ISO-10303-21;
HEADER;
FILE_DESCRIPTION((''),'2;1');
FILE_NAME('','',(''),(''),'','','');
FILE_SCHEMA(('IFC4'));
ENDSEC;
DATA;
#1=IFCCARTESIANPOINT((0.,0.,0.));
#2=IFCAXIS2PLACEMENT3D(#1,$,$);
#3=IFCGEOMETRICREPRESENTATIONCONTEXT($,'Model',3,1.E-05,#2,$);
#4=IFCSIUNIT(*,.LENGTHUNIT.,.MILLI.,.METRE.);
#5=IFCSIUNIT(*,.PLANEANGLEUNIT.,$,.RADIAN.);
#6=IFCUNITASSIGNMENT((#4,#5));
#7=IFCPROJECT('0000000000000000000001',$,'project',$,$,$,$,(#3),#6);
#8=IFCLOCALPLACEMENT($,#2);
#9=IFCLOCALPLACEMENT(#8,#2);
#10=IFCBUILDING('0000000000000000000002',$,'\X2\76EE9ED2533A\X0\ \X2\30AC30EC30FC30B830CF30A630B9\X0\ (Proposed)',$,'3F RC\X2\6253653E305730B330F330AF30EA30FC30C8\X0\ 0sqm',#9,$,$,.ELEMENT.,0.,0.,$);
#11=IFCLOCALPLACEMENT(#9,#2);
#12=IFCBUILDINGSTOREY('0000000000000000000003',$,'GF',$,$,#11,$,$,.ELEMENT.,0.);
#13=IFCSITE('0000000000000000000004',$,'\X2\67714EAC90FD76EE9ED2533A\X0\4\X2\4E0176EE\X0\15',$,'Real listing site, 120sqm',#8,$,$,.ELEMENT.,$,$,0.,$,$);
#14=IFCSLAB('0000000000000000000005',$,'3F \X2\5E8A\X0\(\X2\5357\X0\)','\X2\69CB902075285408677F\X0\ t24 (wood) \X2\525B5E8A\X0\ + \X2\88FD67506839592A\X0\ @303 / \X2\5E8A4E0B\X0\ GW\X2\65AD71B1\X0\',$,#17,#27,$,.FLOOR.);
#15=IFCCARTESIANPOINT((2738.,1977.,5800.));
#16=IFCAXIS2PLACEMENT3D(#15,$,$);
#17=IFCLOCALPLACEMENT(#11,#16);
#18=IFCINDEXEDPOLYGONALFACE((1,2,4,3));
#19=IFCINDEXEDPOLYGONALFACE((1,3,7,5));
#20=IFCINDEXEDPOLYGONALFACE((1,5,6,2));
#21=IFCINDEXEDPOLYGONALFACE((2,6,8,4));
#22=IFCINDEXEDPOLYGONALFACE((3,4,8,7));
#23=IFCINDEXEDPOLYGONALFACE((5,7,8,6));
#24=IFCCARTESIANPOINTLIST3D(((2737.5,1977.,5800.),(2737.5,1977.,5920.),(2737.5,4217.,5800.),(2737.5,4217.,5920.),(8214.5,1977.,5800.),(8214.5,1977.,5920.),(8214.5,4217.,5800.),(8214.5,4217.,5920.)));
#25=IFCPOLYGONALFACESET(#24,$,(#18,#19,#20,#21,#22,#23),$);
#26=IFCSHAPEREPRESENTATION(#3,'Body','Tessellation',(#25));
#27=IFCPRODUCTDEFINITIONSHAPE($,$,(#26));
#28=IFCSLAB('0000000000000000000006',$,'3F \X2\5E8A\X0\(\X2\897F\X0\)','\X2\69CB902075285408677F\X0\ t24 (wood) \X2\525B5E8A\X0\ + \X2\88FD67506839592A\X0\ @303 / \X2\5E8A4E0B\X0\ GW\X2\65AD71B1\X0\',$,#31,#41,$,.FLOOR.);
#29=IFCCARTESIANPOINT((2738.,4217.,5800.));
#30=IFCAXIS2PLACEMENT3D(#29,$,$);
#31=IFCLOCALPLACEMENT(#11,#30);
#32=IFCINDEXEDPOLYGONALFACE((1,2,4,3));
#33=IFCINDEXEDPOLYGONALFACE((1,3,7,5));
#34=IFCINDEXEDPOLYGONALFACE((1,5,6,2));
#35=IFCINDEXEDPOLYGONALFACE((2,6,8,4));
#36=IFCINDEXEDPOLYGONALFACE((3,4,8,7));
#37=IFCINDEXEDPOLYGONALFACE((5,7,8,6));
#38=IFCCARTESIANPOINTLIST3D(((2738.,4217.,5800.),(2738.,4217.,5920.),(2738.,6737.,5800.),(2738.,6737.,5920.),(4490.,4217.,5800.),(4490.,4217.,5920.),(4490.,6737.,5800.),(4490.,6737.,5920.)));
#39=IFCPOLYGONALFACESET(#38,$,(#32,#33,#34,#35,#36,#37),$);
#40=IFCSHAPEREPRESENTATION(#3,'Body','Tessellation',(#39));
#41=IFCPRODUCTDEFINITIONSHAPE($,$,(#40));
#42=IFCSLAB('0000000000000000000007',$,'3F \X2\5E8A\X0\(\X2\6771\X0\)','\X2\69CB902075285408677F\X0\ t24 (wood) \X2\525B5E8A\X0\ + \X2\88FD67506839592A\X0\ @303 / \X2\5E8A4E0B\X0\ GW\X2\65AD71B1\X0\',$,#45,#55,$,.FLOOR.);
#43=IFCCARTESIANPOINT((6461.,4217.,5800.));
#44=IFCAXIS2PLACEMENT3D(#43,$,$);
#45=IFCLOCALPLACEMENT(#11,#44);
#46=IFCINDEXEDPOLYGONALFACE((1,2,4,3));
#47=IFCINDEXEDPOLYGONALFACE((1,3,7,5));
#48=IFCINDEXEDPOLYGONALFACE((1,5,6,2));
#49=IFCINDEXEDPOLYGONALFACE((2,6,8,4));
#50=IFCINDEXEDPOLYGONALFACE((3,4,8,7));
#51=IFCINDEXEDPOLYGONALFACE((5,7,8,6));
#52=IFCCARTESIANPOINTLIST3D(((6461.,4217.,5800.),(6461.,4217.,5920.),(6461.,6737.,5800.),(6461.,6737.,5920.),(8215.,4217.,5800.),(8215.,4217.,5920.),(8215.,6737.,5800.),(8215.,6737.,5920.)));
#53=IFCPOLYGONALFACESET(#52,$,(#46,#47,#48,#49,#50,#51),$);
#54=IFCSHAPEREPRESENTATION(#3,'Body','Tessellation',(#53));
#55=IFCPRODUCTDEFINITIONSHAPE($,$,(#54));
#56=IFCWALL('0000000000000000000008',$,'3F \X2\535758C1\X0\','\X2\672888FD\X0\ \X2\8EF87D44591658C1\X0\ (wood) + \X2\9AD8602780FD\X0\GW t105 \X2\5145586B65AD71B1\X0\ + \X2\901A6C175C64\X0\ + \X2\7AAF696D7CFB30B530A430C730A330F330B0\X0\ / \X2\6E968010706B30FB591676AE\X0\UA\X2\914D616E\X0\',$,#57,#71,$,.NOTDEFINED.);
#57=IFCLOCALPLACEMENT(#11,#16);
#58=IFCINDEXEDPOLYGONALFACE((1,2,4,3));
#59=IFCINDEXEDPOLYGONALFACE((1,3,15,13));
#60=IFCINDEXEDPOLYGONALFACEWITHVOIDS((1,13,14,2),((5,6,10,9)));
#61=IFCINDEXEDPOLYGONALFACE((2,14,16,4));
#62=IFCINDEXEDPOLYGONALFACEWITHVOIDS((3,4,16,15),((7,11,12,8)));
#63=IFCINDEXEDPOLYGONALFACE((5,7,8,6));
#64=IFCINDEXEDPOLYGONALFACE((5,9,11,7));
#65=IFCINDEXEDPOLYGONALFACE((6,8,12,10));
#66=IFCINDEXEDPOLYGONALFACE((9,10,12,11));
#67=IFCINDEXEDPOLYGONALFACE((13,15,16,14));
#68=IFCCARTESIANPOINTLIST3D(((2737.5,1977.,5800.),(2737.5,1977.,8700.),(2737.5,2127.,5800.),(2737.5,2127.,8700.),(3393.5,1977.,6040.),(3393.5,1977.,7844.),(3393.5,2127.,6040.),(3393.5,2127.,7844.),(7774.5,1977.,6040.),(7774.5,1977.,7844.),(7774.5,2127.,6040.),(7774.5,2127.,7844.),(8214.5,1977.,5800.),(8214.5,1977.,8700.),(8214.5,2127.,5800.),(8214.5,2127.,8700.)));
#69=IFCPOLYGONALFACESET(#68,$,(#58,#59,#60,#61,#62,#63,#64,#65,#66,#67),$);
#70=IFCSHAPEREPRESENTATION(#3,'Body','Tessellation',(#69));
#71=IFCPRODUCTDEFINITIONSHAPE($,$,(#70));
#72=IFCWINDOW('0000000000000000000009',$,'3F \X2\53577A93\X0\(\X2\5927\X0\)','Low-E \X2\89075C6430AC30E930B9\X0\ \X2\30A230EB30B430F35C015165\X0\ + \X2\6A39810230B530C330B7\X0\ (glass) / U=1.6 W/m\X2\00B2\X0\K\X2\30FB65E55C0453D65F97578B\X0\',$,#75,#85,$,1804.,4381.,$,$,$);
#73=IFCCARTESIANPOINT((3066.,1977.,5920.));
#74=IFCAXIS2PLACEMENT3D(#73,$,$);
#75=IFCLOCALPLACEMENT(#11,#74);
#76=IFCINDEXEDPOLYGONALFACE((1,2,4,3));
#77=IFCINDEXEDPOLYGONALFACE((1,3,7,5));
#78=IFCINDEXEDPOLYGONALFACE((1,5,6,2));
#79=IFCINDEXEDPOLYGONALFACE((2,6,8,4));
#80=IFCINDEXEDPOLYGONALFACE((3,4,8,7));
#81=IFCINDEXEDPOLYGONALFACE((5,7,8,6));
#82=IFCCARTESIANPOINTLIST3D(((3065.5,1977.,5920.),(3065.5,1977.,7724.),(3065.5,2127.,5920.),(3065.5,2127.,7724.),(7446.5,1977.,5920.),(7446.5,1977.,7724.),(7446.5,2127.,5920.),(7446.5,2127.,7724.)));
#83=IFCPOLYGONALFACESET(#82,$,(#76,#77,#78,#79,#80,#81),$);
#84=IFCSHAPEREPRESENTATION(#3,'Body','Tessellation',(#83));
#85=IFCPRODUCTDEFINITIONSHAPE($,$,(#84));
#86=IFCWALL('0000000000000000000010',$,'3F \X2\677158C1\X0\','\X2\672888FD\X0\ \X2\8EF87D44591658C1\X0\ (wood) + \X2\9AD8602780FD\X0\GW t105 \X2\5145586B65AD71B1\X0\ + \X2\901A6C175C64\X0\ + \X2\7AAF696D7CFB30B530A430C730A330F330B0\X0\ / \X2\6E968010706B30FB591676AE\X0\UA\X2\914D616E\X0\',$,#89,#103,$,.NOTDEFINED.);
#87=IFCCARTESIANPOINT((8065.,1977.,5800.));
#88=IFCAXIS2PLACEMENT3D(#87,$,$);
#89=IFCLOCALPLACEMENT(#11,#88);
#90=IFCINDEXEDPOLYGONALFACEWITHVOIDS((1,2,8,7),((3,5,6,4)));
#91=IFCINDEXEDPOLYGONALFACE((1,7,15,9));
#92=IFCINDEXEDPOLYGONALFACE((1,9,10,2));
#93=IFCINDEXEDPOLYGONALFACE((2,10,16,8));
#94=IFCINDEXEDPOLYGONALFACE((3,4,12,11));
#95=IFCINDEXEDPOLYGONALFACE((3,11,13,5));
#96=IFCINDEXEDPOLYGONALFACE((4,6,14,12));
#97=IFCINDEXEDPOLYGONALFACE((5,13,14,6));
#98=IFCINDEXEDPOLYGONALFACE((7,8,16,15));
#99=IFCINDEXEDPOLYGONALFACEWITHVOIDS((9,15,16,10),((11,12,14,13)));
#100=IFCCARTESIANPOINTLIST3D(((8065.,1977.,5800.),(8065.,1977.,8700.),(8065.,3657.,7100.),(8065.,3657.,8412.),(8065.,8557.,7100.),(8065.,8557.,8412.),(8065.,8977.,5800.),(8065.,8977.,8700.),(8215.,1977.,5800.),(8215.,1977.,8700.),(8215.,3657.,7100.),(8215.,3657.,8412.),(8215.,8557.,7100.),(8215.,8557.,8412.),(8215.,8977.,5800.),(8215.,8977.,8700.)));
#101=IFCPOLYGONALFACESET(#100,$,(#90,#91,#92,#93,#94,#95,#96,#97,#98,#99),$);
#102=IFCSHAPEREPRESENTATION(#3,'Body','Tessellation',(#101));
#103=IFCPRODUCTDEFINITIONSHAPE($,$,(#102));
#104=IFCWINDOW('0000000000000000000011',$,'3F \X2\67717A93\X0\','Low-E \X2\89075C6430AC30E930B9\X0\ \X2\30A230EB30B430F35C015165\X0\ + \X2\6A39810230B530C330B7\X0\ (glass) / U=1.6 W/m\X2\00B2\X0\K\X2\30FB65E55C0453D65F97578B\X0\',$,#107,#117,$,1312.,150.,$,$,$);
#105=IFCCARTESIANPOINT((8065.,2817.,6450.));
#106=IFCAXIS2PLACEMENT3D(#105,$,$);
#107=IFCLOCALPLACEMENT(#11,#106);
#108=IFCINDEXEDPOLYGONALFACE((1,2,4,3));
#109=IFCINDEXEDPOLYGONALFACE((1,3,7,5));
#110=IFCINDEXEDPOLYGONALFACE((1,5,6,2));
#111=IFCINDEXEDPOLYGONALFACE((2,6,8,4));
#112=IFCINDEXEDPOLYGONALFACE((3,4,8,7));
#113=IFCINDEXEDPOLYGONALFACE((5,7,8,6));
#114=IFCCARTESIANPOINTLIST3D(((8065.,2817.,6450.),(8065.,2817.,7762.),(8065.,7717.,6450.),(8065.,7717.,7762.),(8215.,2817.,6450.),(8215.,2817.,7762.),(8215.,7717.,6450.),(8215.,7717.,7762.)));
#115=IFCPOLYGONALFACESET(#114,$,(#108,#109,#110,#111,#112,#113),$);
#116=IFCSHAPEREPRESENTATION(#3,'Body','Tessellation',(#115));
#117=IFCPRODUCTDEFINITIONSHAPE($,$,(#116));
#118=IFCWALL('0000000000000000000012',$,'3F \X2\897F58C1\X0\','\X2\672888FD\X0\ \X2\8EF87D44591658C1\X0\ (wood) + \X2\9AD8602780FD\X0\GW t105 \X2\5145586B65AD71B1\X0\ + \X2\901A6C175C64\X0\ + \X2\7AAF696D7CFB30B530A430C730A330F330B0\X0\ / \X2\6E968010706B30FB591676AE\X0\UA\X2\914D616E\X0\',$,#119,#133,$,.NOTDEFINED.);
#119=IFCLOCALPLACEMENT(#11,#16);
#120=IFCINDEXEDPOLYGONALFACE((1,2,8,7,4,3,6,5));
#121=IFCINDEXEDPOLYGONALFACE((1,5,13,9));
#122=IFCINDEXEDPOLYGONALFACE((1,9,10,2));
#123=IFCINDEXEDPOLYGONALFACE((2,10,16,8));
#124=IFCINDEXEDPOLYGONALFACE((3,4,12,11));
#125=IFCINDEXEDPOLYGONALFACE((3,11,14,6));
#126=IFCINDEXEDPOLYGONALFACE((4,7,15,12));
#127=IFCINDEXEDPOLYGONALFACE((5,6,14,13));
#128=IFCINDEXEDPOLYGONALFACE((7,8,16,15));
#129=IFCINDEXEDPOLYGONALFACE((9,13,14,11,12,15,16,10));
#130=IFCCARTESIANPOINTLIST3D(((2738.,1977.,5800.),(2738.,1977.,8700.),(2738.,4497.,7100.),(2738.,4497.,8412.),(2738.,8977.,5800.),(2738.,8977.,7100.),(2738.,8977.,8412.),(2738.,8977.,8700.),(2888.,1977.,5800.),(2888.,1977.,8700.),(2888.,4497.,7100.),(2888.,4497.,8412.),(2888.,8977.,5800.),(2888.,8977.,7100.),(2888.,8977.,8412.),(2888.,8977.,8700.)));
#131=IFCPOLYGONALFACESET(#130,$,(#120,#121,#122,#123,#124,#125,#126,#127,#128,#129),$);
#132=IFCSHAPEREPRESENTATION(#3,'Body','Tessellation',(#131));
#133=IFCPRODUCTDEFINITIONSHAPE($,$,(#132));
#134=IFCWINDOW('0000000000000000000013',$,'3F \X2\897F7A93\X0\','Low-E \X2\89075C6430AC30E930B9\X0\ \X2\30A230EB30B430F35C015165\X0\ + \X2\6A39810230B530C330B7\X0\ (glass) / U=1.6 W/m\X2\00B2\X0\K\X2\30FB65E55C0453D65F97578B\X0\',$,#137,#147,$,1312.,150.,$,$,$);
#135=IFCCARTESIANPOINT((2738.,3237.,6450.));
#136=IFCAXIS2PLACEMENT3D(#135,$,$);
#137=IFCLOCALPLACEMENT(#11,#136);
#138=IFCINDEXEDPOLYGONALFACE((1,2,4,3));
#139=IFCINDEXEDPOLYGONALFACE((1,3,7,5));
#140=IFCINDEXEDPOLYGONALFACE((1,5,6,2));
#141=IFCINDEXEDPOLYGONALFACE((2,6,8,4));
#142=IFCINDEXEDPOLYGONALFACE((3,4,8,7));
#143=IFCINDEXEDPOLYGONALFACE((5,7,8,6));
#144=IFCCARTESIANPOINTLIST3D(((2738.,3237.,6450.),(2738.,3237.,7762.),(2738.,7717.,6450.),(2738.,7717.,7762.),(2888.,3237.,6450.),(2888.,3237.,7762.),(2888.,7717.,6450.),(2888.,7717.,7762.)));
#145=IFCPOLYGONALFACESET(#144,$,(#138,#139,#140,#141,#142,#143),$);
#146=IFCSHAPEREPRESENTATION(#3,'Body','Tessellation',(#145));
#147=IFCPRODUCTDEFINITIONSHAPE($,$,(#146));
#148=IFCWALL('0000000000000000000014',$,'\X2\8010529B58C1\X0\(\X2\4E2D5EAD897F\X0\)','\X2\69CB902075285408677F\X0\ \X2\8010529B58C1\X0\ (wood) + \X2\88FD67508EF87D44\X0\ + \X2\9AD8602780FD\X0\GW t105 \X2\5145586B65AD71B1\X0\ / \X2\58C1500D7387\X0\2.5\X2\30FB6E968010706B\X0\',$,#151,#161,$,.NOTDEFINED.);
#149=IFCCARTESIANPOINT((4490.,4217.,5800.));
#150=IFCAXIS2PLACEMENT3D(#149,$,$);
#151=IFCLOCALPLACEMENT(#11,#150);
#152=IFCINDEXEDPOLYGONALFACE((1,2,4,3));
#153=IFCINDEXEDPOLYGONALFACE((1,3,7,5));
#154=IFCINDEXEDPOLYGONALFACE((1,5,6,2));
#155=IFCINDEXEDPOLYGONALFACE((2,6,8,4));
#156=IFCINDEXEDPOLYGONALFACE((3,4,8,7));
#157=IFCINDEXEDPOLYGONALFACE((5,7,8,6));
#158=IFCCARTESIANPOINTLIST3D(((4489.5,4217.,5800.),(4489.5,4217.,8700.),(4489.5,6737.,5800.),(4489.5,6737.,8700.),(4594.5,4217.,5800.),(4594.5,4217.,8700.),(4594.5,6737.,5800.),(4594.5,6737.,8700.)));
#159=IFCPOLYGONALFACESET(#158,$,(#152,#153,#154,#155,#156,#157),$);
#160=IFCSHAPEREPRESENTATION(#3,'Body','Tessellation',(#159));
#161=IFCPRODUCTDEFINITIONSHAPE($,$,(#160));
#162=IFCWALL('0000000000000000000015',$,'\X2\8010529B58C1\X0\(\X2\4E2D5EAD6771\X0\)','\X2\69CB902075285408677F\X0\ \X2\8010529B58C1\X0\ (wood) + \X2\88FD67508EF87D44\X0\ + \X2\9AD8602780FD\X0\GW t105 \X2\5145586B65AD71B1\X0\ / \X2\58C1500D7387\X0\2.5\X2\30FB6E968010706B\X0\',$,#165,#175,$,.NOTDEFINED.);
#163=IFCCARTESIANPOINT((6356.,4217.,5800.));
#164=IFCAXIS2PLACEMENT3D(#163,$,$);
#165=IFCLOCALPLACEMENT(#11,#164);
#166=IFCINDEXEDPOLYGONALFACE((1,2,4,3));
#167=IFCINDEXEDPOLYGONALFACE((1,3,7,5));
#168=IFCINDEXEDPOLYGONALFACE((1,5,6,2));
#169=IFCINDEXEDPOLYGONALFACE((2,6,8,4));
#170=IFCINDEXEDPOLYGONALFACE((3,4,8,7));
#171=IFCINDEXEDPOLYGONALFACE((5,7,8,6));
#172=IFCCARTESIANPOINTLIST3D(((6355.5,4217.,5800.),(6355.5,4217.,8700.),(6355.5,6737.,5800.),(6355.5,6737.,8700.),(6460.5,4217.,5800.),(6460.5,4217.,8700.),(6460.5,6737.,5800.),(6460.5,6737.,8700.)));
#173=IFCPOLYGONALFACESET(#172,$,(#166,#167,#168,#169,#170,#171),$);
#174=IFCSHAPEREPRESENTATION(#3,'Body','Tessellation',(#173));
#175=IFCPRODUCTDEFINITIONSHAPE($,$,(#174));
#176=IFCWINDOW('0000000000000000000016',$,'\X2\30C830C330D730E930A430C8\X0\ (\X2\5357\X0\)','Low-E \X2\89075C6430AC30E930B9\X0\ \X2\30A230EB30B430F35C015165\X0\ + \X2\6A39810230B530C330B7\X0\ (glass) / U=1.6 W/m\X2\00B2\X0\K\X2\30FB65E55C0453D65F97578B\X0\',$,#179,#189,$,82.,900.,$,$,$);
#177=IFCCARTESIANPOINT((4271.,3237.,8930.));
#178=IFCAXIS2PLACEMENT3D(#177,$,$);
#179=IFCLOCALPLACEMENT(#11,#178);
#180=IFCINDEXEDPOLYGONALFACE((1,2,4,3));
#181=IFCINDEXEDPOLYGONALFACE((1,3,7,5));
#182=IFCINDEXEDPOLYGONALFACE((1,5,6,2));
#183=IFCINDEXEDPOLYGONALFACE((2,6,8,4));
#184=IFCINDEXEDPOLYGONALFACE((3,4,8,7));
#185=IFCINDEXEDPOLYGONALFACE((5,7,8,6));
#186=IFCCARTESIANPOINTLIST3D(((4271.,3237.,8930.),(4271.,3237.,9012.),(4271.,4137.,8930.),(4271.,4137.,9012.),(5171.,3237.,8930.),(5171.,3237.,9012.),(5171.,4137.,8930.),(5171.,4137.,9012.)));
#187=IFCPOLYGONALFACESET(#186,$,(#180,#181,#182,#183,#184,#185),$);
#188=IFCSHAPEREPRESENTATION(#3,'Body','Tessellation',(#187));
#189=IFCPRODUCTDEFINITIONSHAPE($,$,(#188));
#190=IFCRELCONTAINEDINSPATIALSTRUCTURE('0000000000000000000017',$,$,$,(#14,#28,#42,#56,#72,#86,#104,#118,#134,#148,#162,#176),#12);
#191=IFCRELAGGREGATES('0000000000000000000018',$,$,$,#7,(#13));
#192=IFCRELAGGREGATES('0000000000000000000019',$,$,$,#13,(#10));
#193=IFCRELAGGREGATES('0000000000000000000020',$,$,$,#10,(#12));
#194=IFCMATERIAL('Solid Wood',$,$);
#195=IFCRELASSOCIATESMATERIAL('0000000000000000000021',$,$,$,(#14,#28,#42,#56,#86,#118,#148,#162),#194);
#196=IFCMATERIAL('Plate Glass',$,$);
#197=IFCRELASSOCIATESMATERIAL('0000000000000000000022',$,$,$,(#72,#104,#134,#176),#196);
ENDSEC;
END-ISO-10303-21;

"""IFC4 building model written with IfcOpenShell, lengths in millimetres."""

from ifc_helpers import new_model, si_unit, frame, frame_2d, origin, place, context, project, spatial, rectangle, extrude, material, element, fill, save


model = new_model("IFC4")

# Units and contexts
model_context = context("Model", 3, precision=1e-05, world=origin())
ifc_project = project(units=[si_unit("LENGTHUNIT", "METRE", prefix="MILLI"), si_unit("PLANEANGLEUNIT", "RADIAN")], contexts=[model_context])

# Site, building, storey
site_placement = place(None, origin())
site = spatial("IfcSite", under=ifc_project, at=site_placement, Name="東京都目黒区4丁目15", ObjectType="Real listing site, 120sqm", CompositionType="ELEMENT", RefElevation=0.0)
building_placement = place(site_placement, origin())
building = spatial("IfcBuilding", under=site, at=building_placement, Name="目黒区 ガレージハウス (Proposed)", ObjectType="3F RC打放しコンクリート 0sqm", CompositionType="ELEMENT", ElevationOfRefHeight=0.0, ElevationOfTerrain=0.0)
storey_placement = place(building_placement, origin())
storey = spatial("IfcBuildingStorey", under=building, at=storey_placement, Name="GF", CompositionType="ELEMENT", Elevation=0.0)

# Slabs
ifc_material_1 = material(Name="Solid Wood")
slab_1_placement = place(storey_placement, frame((2738.0, 1977.0, 5800.0)))
element("IfcSlab", 1, at=slab_1_placement, inside=storey, material=ifc_material_1, Name="3F 床(南)", Description="構造用合板 t24 (wood) 剛床 + 製材根太 @303 / 床下 GW断熱", PredefinedType="FLOOR", context=model_context, shape_type="SweptSolid", body=[
    extrude(rectangle(XDim=5477.0, YDim=2240.0, at=frame_2d((2738.0, 1120.0))), frame((2738.0, 1977.0, 5800.0)), (0.0, 0.0, 1.0), 120.0),
])
slab_2_placement = place(storey_placement, frame((2738.0, 4217.0, 5800.0)))
element("IfcSlab", 2, at=slab_2_placement, inside=storey, material=ifc_material_1, Name="3F 床(西)", Description="構造用合板 t24 (wood) 剛床 + 製材根太 @303 / 床下 GW断熱", PredefinedType="FLOOR", context=model_context, shape_type="SweptSolid", body=[
    extrude(rectangle(XDim=1752.0, YDim=2520.0, at=frame_2d((876.0, 1260.0))), frame((2738.0, 4217.0, 5800.0)), (0.0, 0.0, 1.0), 120.0),
])
slab_3_placement = place(storey_placement, frame((6461.0, 4217.0, 5800.0)))
element("IfcSlab", 3, at=slab_3_placement, inside=storey, material=ifc_material_1, Name="3F 床(東)", Description="構造用合板 t24 (wood) 剛床 + 製材根太 @303 / 床下 GW断熱", PredefinedType="FLOOR", context=model_context, shape_type="SweptSolid", body=[
    extrude(rectangle(XDim=1754.0, YDim=2520.0, at=frame_2d((877.0, 1260.0))), frame((6461.0, 4217.0, 5800.0)), (0.0, 0.0, 1.0), 120.0),
])

# Walls, openings, windows
wall_1_placement = place(storey_placement, frame((2738.0, 1977.0, 5800.0)))
wall_1 = element("IfcWall", 4, at=wall_1_placement, inside=storey, material=ifc_material_1, Name="3F 南壁", Description="木製 軸組外壁 (wood) + 高性能GW t105 充填断熱 + 通気層 + 窯業系サイディング / 準耐火・外皮UA配慮", PredefinedType="NOTDEFINED", context=model_context, shape_type="SweptSolid", body=[
    extrude(rectangle(XDim=5477.0, YDim=150.0, at=frame_2d((2738.0, 75.0))), frame((2738.0, 1977.0, 5800.0)), (0.0, 0.0, 1.0), 2900.0),
])
opening_1_placement = place(storey_placement, frame((3066.0, 1977.0, 5920.0)))
opening_1 = element("IfcOpeningElement", 5, at=opening_1_placement, cuts=wall_1, PredefinedType="NOTDEFINED", context=model_context, shape_type="SweptSolid", body=[
    extrude(rectangle(XDim=4381.0, YDim=150.0, at=frame_2d((2190.0, 75.0))), frame((3066.0, 1977.0, 5920.0)), (0.0, 0.0, 1.0), 1804.0),
])
ifc_material_2 = material(Name="Plate Glass")
window_1_placement = place(storey_placement, frame((3066.0, 1977.0, 5920.0)))
window_1 = element("IfcWindow", 6, at=window_1_placement, inside=storey, material=ifc_material_2, Name="3F 南窓(大)", Description="Low-E 複層ガラス アルゴン封入 + 樹脂サッシ (glass) / U=1.6 W/m²K・日射取得型", OverallHeight=1804.0, OverallWidth=4381.0, context=model_context, shape_type="SweptSolid", body=[
    extrude(rectangle(XDim=4381.0, YDim=150.0, at=frame_2d((2190.0, 75.0))), frame((3066.0, 1977.0, 5920.0)), (0.0, 0.0, 1.0), 1804.0),
])
fill(opening_1, window_1)
wall_2_placement = place(storey_placement, frame((8065.0, 1977.0, 5800.0)))
wall_2 = element("IfcWall", 7, at=wall_2_placement, inside=storey, material=ifc_material_1, Name="3F 東壁", Description="木製 軸組外壁 (wood) + 高性能GW t105 充填断熱 + 通気層 + 窯業系サイディング / 準耐火・外皮UA配慮", PredefinedType="NOTDEFINED", context=model_context, shape_type="SweptSolid", body=[
    extrude(rectangle(XDim=150.0, YDim=7000.0, at=frame_2d((75.0, 3500.0))), frame((8065.0, 1977.0, 5800.0)), (0.0, 0.0, 1.0), 2900.0),
])
opening_2_placement = place(storey_placement, frame((8065.0, 2817.0, 6450.0)))
opening_2 = element("IfcOpeningElement", 8, at=opening_2_placement, cuts=wall_2, PredefinedType="NOTDEFINED", context=model_context, shape_type="SweptSolid", body=[
    extrude(rectangle(XDim=150.0, YDim=4900.0, at=frame_2d((75.0, 2450.0))), frame((8065.0, 2817.0, 6450.0)), (0.0, 0.0, 1.0), 1312.0),
])
window_2_placement = place(storey_placement, frame((8065.0, 2817.0, 6450.0)))
window_2 = element("IfcWindow", 9, at=window_2_placement, inside=storey, material=ifc_material_2, Name="3F 東窓", Description="Low-E 複層ガラス アルゴン封入 + 樹脂サッシ (glass) / U=1.6 W/m²K・日射取得型", OverallHeight=1312.0, OverallWidth=150.0, context=model_context, shape_type="SweptSolid", body=[
    extrude(rectangle(XDim=150.0, YDim=4900.0, at=frame_2d((75.0, 2450.0))), frame((8065.0, 2817.0, 6450.0)), (0.0, 0.0, 1.0), 1312.0),
])
fill(opening_2, window_2)
wall_3_placement = place(storey_placement, frame((2738.0, 1977.0, 5800.0)))
wall_3 = element("IfcWall", 10, at=wall_3_placement, inside=storey, material=ifc_material_1, Name="3F 西壁", Description="木製 軸組外壁 (wood) + 高性能GW t105 充填断熱 + 通気層 + 窯業系サイディング / 準耐火・外皮UA配慮", PredefinedType="NOTDEFINED", context=model_context, shape_type="SweptSolid", body=[
    extrude(rectangle(XDim=150.0, YDim=7000.0, at=frame_2d((75.0, 3500.0))), frame((2738.0, 1977.0, 5800.0)), (0.0, 0.0, 1.0), 2900.0),
])
opening_3_placement = place(storey_placement, frame((2738.0, 3237.0, 6450.0)))
opening_3 = element("IfcOpeningElement", 11, at=opening_3_placement, cuts=wall_3, PredefinedType="NOTDEFINED", context=model_context, shape_type="SweptSolid", body=[
    extrude(rectangle(XDim=150.0, YDim=4480.0, at=frame_2d((75.0, 2240.0))), frame((2738.0, 3237.0, 6450.0)), (0.0, 0.0, 1.0), 1312.0),
])
window_3_placement = place(storey_placement, frame((2738.0, 3237.0, 6450.0)))
window_3 = element("IfcWindow", 12, at=window_3_placement, inside=storey, material=ifc_material_2, Name="3F 西窓", Description="Low-E 複層ガラス アルゴン封入 + 樹脂サッシ (glass) / U=1.6 W/m²K・日射取得型", OverallHeight=1312.0, OverallWidth=150.0, context=model_context, shape_type="SweptSolid", body=[
    extrude(rectangle(XDim=150.0, YDim=4480.0, at=frame_2d((75.0, 2240.0))), frame((2738.0, 3237.0, 6450.0)), (0.0, 0.0, 1.0), 1312.0),
])
fill(opening_3, window_3)

# Walls
wall_4_placement = place(storey_placement, frame((4490.0, 4217.0, 5800.0)))
element("IfcWall", 13, at=wall_4_placement, inside=storey, material=ifc_material_1, Name="耐力壁(中庭西)", Description="構造用合板 耐力壁 (wood) + 製材軸組 + 高性能GW t105 充填断熱 / 壁倍率2.5・準耐火", PredefinedType="NOTDEFINED", context=model_context, shape_type="SweptSolid", body=[
    extrude(rectangle(XDim=105.0, YDim=2520.0, at=frame_2d((52.0, 1260.0))), frame((4490.0, 4217.0, 5800.0)), (0.0, 0.0, 1.0), 2900.0),
])
wall_5_placement = place(storey_placement, frame((6356.0, 4217.0, 5800.0)))
element("IfcWall", 14, at=wall_5_placement, inside=storey, material=ifc_material_1, Name="耐力壁(中庭東)", Description="構造用合板 耐力壁 (wood) + 製材軸組 + 高性能GW t105 充填断熱 / 壁倍率2.5・準耐火", PredefinedType="NOTDEFINED", context=model_context, shape_type="SweptSolid", body=[
    extrude(rectangle(XDim=105.0, YDim=2520.0, at=frame_2d((52.0, 1260.0))), frame((6356.0, 4217.0, 5800.0)), (0.0, 0.0, 1.0), 2900.0),
])

# Window
window_4_placement = place(storey_placement, frame((4271.0, 3237.0, 8930.0)))
element("IfcWindow", 15, at=window_4_placement, inside=storey, material=ifc_material_2, Name="トップライト (南)", Description="Low-E 複層ガラス アルゴン封入 + 樹脂サッシ (glass) / U=1.6 W/m²K・日射取得型", OverallHeight=82.0, OverallWidth=900.0, context=model_context, shape_type="SweptSolid", body=[
    extrude(rectangle(XDim=900.0, YDim=900.0, at=frame_2d((450.0, 450.0))), frame((4271.0, 3237.0, 8930.0)), (0.0, 0.0, 1.0), 82.0),
])

save(model, "model.ifc")
